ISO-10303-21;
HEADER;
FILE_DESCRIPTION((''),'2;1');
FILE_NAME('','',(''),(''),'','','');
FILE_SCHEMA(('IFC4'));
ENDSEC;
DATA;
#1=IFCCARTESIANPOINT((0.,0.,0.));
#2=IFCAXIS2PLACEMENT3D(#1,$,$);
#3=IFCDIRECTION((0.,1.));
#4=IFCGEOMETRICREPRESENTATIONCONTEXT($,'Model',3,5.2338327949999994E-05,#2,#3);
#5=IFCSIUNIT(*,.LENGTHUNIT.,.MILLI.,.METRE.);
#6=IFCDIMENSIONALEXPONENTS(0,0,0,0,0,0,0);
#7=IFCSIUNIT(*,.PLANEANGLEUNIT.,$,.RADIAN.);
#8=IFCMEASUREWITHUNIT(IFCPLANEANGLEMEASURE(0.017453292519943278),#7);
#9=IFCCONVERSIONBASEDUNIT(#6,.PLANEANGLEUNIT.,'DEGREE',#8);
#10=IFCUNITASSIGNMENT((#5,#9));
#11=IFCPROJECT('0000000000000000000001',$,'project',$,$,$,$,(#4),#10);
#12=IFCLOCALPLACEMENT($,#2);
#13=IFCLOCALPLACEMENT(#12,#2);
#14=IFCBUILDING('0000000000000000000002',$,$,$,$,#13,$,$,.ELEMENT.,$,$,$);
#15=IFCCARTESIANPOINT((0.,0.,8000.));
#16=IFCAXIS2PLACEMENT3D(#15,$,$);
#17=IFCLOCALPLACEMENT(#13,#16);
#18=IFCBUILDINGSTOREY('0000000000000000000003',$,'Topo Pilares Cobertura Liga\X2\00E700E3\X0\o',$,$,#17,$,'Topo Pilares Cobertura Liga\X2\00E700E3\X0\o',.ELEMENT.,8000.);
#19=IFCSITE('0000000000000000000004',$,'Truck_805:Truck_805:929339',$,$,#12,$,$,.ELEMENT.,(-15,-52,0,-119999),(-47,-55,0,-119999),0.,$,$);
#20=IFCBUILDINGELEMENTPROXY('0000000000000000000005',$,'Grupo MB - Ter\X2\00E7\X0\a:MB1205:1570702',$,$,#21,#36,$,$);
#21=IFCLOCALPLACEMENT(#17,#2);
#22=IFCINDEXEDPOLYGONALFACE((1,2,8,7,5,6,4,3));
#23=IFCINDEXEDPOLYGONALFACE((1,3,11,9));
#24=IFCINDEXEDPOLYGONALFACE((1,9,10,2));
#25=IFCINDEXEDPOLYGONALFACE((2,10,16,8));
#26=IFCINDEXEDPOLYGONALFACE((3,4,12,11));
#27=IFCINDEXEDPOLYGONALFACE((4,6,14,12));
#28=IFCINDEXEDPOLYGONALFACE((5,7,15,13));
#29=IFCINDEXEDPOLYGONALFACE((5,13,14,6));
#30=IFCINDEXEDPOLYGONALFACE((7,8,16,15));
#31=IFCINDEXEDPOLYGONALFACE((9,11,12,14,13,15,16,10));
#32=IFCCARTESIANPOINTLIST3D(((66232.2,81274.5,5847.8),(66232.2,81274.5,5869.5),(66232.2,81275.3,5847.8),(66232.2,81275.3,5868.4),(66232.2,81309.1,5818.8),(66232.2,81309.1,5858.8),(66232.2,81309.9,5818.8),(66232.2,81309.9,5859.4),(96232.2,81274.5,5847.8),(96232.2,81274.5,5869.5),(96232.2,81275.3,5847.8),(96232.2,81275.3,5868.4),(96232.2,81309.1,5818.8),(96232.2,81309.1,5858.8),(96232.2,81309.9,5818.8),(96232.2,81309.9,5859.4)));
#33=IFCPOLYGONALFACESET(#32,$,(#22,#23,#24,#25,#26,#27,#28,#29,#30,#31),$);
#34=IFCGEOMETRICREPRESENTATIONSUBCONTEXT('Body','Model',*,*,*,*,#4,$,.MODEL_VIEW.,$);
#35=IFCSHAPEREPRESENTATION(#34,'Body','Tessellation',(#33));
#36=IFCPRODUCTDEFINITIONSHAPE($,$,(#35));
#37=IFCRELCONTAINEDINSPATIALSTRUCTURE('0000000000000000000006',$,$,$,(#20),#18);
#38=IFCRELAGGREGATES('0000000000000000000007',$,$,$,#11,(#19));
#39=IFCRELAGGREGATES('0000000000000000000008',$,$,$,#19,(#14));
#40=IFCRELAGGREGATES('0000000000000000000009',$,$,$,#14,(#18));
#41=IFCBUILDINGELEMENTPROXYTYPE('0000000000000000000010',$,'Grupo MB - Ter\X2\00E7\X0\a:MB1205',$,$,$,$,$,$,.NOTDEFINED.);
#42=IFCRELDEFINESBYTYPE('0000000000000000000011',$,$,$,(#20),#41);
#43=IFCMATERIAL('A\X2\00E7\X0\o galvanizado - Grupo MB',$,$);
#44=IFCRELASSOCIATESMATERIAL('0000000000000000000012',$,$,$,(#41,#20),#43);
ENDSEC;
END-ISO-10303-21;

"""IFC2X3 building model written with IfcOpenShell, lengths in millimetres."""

from ifc_helpers import new_model, entity, si_unit, converted_unit, direction, frame, origin, place, context, subcontext, project, spatial, polyline, outline, extrude, source, transform, mapped, material, type_object, type_shapes, element, save


model = new_model("IFC2X3")

# Units and contexts
model_context = context("Model", 3, precision=5.2338327949999994e-05, world=origin(), true_north=direction((0.0, 1.0)))
body_context = subcontext(model_context, "Body", "Model", "MODEL_VIEW")
ifc_project = project(units=[si_unit("LENGTHUNIT", "METRE", prefix="MILLI"), converted_unit("PLANEANGLEUNIT", "DEGREE", entity("IfcPlaneAngleMeasure", 0.017453292519943278), si_unit("PLANEANGLEUNIT", "RADIAN"), dimensions=[0, 0, 0, 0, 0, 0, 0])], contexts=[model_context])

# Site, building, storey
site_placement = place(None, origin())
site = spatial("IfcSite", under=ifc_project, at=site_placement, Name="Truck_805:Truck_805:929339", CompositionType="ELEMENT", RefLatitude=(-15, -52, 0, -119999), RefLongitude=(-47, -55, 0, -119999), RefElevation=0.0)
building_placement = place(site_placement, origin())
building = spatial("IfcBuilding", under=site, at=building_placement, CompositionType="ELEMENT")
storey_placement = place(building_placement, frame((0.0, 0.0, 8000.0)))
storey = spatial("IfcBuildingStorey", under=building, at=storey_placement, Name="Topo Pilares Cobertura Ligação", LongName="Topo Pilares Cobertura Ligação", CompositionType="ELEMENT", Elevation=8000.0)

# Building element proxy
ifc_material_1 = material(Name="Aço galvanizado - Grupo MB")
building_element_proxy_type_1 = type_object("IfcBuildingElementProxyType", Name="Grupo MB - Terça:MB1205", PredefinedType="NOTDEFINED", material=ifc_material_1)
shared_shape_1 = source(origin(), body_context, "Body", "SweptSolid", [
    extrude(outline(polyline([(-13.5, -14.4), (-24.4, 24.1), (-25.2, 23.9), (-14.1, -15.2), (22.7, -15.2), (16.8, 5.7), (16.0, 5.4), (21.6, -14.4), (-13.5, -14.4)])), frame((0.0, 16.9, -10.1), z_axis=(-1.0, 0.0, 0.0), x_axis=(0.0, 0.961789, 0.273791)), (0.0, 0.0, -1.0), 30000.0),
])
type_shapes(building_element_proxy_type_1, [shared_shape_1])
proxy_1_placement = place(storey_placement, frame((96232.2, 81309.1, 5858.8), z_axis=(0.0, 0.0, 1.0), x_axis=(-1.0, 0.0, 0.0)))
element("IfcBuildingElementProxy", 1, at=proxy_1_placement, inside=storey, type_object=building_element_proxy_type_1, material=ifc_material_1, Name="Grupo MB - Terça:MB1205:1570702", context=body_context, shape_type="MappedRepresentation", body=[
    mapped(shared_shape_1, transform((0.0, 0.0, 0.0), scale=1.0)),
])

save(model, "model.ifc")
